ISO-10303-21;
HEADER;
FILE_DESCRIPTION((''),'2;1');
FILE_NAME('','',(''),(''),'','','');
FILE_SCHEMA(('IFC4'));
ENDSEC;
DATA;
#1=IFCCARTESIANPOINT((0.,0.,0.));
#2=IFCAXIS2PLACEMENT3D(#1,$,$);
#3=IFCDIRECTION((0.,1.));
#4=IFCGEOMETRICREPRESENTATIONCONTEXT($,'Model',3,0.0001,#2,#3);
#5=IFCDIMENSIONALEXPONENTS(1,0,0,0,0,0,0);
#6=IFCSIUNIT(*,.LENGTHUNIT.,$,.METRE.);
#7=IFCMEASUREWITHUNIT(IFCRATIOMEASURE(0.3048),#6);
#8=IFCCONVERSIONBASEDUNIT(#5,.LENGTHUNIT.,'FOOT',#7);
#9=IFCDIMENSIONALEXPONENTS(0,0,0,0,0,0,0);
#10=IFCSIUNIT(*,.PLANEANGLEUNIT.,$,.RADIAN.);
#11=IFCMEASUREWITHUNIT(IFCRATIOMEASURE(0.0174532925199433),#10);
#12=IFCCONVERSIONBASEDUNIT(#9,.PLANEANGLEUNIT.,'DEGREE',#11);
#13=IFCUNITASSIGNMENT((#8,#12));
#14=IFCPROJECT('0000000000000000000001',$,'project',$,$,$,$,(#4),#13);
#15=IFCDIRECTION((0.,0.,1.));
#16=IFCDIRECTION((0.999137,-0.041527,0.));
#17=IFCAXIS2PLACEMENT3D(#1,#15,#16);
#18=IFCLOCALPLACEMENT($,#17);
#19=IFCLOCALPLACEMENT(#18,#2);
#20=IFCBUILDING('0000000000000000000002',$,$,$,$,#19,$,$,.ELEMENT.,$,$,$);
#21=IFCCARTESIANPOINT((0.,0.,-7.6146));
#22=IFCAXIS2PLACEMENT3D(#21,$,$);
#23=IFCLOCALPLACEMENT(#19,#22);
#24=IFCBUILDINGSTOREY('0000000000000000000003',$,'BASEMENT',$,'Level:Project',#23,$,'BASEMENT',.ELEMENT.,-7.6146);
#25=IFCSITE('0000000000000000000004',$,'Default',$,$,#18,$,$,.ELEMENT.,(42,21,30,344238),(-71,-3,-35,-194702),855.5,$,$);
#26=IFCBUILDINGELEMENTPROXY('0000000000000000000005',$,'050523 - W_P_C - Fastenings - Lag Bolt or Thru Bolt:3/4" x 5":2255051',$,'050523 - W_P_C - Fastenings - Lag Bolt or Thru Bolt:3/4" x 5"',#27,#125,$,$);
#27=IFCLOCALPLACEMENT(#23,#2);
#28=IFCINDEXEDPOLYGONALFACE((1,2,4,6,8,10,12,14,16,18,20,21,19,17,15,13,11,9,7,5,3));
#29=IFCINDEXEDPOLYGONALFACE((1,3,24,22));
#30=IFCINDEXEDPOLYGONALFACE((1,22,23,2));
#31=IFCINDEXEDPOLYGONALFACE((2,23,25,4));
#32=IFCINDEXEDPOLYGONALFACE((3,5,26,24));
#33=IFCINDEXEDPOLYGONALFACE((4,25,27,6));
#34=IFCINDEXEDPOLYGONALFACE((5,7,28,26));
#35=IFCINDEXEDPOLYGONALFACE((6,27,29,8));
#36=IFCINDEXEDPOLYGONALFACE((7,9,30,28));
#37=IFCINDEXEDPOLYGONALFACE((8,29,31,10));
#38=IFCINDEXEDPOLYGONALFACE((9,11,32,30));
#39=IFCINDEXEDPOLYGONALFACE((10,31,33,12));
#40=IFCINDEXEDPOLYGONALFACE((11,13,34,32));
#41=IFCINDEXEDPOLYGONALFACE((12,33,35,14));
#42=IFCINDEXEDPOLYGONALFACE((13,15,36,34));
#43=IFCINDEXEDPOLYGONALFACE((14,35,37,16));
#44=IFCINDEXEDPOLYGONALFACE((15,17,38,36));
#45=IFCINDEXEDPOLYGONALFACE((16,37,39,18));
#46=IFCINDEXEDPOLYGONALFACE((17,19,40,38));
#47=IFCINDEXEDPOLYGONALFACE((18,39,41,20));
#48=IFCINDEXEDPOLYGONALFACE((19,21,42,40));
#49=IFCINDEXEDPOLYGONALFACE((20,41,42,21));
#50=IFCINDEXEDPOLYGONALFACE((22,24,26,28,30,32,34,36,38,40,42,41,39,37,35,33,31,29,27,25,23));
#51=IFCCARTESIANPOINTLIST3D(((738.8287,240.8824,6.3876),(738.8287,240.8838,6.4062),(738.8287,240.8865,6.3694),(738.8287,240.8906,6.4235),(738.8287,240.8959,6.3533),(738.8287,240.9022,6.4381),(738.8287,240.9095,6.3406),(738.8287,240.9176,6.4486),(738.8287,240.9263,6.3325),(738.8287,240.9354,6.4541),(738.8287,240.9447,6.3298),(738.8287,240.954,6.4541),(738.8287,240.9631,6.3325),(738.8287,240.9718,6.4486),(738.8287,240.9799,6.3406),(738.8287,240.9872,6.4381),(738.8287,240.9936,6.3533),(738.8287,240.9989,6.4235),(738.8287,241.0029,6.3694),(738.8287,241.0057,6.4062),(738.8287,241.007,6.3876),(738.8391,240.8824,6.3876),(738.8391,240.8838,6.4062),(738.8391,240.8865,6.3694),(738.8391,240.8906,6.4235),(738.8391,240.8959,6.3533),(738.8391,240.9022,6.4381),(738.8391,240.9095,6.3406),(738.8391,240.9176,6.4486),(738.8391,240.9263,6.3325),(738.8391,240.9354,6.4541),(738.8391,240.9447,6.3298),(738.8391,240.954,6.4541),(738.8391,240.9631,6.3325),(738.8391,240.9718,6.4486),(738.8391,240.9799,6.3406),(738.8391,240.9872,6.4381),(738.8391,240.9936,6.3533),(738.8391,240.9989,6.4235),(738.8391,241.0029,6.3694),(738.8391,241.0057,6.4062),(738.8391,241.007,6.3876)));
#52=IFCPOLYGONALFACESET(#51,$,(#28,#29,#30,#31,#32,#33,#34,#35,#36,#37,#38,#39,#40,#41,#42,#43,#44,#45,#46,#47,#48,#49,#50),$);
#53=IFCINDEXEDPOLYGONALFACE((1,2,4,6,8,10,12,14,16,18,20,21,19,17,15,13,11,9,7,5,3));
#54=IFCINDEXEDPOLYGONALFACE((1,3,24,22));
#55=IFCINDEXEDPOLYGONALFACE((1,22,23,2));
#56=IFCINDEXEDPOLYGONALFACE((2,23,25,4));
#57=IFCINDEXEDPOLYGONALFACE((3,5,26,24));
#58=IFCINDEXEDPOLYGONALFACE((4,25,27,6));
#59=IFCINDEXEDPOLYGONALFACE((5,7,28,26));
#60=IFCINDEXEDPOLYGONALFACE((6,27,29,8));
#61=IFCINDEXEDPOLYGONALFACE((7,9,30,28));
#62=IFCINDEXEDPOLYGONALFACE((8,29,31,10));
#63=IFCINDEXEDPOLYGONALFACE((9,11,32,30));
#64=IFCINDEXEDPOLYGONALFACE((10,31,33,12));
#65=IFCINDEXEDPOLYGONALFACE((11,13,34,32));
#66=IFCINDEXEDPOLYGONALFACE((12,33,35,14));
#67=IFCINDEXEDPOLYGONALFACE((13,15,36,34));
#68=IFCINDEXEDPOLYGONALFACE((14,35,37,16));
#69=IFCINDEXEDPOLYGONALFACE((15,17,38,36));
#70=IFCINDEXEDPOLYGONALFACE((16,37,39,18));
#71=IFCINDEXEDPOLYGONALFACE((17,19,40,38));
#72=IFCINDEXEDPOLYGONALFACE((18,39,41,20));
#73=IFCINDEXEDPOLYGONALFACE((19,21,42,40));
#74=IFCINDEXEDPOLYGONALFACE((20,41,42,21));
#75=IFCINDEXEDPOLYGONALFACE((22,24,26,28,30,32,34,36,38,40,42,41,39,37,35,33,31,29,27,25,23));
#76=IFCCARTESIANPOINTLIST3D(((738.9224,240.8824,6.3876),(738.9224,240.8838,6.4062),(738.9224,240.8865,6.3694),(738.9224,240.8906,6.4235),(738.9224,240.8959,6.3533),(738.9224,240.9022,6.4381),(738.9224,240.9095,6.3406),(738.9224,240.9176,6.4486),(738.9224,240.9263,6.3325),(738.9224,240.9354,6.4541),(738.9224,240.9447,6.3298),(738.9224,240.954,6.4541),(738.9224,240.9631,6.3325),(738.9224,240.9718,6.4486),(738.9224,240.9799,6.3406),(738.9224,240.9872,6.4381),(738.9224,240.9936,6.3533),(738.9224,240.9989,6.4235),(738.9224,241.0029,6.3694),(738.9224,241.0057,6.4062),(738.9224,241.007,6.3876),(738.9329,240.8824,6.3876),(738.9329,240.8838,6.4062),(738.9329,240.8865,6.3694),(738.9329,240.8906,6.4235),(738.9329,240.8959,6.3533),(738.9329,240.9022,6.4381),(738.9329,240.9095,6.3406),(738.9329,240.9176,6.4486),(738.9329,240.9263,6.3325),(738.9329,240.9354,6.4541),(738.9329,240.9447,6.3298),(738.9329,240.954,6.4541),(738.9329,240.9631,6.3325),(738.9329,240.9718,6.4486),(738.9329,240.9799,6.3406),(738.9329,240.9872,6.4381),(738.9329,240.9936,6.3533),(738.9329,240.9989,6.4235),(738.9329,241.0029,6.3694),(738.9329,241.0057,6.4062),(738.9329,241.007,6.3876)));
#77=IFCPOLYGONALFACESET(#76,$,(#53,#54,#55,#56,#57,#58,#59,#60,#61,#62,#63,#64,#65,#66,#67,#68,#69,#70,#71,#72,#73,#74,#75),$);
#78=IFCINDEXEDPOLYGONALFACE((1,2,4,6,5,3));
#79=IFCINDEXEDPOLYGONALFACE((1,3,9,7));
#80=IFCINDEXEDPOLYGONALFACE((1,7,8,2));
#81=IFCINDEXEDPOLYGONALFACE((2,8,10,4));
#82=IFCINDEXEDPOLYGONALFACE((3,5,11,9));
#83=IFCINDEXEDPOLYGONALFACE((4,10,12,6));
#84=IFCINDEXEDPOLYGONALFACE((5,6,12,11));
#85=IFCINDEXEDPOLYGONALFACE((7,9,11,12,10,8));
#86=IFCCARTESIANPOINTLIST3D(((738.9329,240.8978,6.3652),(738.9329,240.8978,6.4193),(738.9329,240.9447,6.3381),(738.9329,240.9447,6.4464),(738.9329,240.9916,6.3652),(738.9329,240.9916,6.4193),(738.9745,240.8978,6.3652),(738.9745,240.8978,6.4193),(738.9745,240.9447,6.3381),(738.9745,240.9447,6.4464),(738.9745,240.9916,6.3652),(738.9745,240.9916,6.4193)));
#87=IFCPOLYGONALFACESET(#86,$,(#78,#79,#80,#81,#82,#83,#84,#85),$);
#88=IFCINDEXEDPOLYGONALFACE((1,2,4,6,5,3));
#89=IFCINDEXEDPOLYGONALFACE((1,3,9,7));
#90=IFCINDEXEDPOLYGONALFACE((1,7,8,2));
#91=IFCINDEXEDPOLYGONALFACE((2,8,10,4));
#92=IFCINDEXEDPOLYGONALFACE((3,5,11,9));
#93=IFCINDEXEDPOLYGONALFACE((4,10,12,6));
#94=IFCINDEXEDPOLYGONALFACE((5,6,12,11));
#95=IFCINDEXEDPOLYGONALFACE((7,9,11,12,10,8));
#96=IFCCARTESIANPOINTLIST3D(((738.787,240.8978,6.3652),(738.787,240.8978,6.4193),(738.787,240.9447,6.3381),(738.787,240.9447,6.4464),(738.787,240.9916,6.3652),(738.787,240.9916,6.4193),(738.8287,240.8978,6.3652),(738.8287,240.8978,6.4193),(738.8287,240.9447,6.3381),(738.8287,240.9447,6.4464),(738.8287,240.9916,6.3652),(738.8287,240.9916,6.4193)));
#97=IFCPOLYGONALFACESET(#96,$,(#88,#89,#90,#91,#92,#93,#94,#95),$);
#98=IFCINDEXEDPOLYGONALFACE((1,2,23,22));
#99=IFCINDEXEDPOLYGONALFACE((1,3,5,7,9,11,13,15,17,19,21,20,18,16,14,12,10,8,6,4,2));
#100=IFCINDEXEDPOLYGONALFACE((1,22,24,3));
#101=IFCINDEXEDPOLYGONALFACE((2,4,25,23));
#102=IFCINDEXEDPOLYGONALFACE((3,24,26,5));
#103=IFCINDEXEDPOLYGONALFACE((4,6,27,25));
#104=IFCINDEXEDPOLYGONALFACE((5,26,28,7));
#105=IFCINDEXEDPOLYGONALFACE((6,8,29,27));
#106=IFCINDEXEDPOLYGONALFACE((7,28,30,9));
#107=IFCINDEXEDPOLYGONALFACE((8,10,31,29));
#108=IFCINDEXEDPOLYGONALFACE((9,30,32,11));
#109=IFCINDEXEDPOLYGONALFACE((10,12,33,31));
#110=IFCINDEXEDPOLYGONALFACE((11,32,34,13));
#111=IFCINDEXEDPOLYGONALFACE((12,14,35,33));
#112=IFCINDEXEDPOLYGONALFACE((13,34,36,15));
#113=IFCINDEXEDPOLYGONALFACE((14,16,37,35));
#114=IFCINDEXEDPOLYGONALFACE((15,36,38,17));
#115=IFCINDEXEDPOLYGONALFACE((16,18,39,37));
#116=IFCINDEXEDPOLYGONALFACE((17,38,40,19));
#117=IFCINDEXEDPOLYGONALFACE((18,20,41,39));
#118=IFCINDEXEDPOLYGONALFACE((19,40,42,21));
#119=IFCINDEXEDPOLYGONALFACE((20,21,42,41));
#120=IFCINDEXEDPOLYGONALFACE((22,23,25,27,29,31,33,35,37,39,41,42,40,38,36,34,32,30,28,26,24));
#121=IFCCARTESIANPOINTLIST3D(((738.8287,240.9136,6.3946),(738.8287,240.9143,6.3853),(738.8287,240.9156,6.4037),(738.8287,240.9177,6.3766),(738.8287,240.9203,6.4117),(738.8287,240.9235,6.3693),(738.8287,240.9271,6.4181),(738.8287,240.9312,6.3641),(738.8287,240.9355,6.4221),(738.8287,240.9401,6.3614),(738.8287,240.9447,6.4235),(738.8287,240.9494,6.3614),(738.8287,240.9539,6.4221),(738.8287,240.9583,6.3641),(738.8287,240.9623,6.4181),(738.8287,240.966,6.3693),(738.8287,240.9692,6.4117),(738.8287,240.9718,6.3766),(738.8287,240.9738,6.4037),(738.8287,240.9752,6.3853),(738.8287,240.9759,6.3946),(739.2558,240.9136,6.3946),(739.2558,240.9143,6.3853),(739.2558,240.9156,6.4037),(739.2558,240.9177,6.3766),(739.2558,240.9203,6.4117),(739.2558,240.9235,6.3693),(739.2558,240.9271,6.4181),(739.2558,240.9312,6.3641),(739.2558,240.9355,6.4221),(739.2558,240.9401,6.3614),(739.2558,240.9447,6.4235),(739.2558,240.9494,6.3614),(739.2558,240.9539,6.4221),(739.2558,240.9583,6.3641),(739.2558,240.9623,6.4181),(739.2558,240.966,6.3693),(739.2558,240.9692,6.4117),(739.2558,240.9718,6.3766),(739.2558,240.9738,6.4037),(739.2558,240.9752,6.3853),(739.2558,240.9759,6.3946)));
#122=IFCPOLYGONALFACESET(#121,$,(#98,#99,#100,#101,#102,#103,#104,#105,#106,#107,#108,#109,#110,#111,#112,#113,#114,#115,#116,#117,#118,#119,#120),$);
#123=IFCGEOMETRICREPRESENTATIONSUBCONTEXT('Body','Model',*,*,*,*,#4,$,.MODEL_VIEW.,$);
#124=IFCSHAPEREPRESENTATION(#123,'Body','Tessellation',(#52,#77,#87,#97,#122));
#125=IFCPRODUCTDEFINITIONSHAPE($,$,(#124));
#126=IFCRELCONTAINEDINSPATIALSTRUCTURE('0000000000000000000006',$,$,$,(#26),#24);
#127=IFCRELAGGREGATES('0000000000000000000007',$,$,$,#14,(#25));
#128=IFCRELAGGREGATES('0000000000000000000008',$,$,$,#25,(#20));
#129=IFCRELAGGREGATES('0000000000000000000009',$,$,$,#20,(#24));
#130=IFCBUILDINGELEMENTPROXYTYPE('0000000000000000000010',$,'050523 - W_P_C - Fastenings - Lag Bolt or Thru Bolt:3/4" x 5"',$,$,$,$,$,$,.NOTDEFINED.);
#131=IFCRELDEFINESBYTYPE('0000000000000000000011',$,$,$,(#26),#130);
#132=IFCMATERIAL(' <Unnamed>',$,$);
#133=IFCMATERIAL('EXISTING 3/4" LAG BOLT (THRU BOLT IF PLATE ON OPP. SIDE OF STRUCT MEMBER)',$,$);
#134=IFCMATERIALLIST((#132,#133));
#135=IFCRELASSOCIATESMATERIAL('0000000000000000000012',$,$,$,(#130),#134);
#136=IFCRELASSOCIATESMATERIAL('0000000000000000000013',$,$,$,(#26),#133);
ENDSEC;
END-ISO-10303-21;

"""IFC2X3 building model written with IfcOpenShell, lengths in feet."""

from ifc_helpers import new_model, entity, si_unit, converted_unit, direction, frame, frame_2d, origin, place, context, subcontext, project, spatial, polyline, circle, outline, extrude, source, transform, mapped, material, material_list, type_object, type_shapes, element, save


model = new_model("IFC2X3")

# Units and contexts
model_context = context("Model", 3, precision=0.0001, world=origin(), true_north=direction((0.0, 1.0)))
body_context = subcontext(model_context, "Body", "Model", "MODEL_VIEW")
ifc_project = project(units=[converted_unit("LENGTHUNIT", "FOOT", entity("IfcRatioMeasure", 0.3048), si_unit("LENGTHUNIT", "METRE"), dimensions=[1, 0, 0, 0, 0, 0, 0]), converted_unit("PLANEANGLEUNIT", "DEGREE", entity("IfcRatioMeasure", 0.0174532925199433), si_unit("PLANEANGLEUNIT", "RADIAN"), dimensions=[0, 0, 0, 0, 0, 0, 0])], contexts=[model_context])

# Site, building, storey
site_placement = place(None, frame((0.0, 0.0, 0.0), z_axis=(0.0, 0.0, 1.0), x_axis=(0.999137, -0.041527, 0.0)))
site = spatial("IfcSite", under=ifc_project, at=site_placement, Name="Default", CompositionType="ELEMENT", RefLatitude=(42, 21, 30, 344238), RefLongitude=(-71, -3, -35, -194702), RefElevation=855.5)
building_placement = place(site_placement, origin())
building = spatial("IfcBuilding", under=site, at=building_placement, CompositionType="ELEMENT")
storey_placement = place(building_placement, frame((0.0, 0.0, -7.6146)))
storey = spatial("IfcBuildingStorey", under=building, at=storey_placement, Name="BASEMENT", ObjectType="Level:Project", LongName="BASEMENT", CompositionType="ELEMENT", Elevation=-7.6146)

# Building element proxy
ifc_material_1 = material(Name="EXISTING 3/4\" LAG BOLT (THRU BOLT IF PLATE ON OPP. SIDE OF STRUCT MEMBER)")
ifc_material_2 = material(Name=" <Unnamed>")
ifc_material_list_1 = material_list([ifc_material_2, ifc_material_1])
building_element_proxy_type_1 = type_object("IfcBuildingElementProxyType", Name="050523 - W_P_C - Fastenings - Lag Bolt or Thru Bolt:3/4\" x 5\"", PredefinedType="NOTDEFINED", material=ifc_material_list_1)
shared_shape_1 = source(origin(), body_context, "Body", "SweptSolid", [
    extrude(circle(Radius=0.0625, at=frame_2d((0.0, 0.0), x_axis=(1.0, 0.0))), frame((0.0, 0.0, 0.0), z_axis=(0.0, 0.0, 1.0), x_axis=(0.0, -1.0, 0.0)), (0.0, 0.0, 1.0), 0.0104),
    extrude(circle(Radius=0.0625, at=frame_2d((0.0, 0.0), x_axis=(1.0, 0.0))), frame((0.0, 0.0, -0.0938), z_axis=(0.0, 0.0, 1.0), x_axis=(0.0, -1.0, 0.0)), (0.0, 0.0, 1.0), 0.0104),
    extrude(outline(polyline([(-0.0271, -0.0469), (0.0271, -0.0469), (0.0541, 0.0), (0.0271, 0.0469), (-0.0271, 0.0469), (-0.0541, 0.0), (-0.0271, -0.0469)])), frame((0.0, 0.0, -0.1354), z_axis=(0.0, 0.0, 1.0), x_axis=(0.866025, -0.5, 0.0)), (0.0, 0.0, 1.0), 0.0417),
    extrude(outline(polyline([(-0.0271, -0.0469), (0.0271, -0.0469), (0.0541, 0.0), (0.0271, 0.0469), (-0.0271, 0.0469), (-0.0541, 0.0), (-0.0271, -0.0469)])), frame((0.0, 0.0, 0.0104), z_axis=(0.0, 0.0, 1.0), x_axis=(0.0, -1.0, 0.0)), (0.0, 0.0, 1.0), 0.0417),
    extrude(circle(Radius=0.0312, at=frame_2d((0.0, 0.0), x_axis=(1.0, 0.0))), frame((0.0, 0.0, -0.4167), z_axis=(0.0, 0.0, 1.0), x_axis=(0.0, 1.0, 0.0)), (0.0, 0.0, 1.0), 0.4271),
])
type_shapes(building_element_proxy_type_1, [shared_shape_1])
for number, where, z_axis, x_axis, name in (
    (1, (738.8391, 240.9447, 6.3923), (-1.0, 0.0, 0.0), (0.0, -1.0, 0.0), "050523 - W_P_C - Fastenings - Lag Bolt or Thru Bolt:3/4\" x 5\":2255051"),
):
    element("IfcBuildingElementProxy", number, at=place(storey_placement, frame(where, z_axis=z_axis, x_axis=x_axis)), inside=storey, type_object=building_element_proxy_type_1, material=ifc_material_1, Name=name, ObjectType="050523 - W_P_C - Fastenings - Lag Bolt or Thru Bolt:3/4\" x 5\"", context=body_context, shape_type="MappedRepresentation", body=[
        mapped(shared_shape_1, transform((0.0, 0.0, 0.0), scale=1.0)),
    ])

save(model, "model.ifc")
